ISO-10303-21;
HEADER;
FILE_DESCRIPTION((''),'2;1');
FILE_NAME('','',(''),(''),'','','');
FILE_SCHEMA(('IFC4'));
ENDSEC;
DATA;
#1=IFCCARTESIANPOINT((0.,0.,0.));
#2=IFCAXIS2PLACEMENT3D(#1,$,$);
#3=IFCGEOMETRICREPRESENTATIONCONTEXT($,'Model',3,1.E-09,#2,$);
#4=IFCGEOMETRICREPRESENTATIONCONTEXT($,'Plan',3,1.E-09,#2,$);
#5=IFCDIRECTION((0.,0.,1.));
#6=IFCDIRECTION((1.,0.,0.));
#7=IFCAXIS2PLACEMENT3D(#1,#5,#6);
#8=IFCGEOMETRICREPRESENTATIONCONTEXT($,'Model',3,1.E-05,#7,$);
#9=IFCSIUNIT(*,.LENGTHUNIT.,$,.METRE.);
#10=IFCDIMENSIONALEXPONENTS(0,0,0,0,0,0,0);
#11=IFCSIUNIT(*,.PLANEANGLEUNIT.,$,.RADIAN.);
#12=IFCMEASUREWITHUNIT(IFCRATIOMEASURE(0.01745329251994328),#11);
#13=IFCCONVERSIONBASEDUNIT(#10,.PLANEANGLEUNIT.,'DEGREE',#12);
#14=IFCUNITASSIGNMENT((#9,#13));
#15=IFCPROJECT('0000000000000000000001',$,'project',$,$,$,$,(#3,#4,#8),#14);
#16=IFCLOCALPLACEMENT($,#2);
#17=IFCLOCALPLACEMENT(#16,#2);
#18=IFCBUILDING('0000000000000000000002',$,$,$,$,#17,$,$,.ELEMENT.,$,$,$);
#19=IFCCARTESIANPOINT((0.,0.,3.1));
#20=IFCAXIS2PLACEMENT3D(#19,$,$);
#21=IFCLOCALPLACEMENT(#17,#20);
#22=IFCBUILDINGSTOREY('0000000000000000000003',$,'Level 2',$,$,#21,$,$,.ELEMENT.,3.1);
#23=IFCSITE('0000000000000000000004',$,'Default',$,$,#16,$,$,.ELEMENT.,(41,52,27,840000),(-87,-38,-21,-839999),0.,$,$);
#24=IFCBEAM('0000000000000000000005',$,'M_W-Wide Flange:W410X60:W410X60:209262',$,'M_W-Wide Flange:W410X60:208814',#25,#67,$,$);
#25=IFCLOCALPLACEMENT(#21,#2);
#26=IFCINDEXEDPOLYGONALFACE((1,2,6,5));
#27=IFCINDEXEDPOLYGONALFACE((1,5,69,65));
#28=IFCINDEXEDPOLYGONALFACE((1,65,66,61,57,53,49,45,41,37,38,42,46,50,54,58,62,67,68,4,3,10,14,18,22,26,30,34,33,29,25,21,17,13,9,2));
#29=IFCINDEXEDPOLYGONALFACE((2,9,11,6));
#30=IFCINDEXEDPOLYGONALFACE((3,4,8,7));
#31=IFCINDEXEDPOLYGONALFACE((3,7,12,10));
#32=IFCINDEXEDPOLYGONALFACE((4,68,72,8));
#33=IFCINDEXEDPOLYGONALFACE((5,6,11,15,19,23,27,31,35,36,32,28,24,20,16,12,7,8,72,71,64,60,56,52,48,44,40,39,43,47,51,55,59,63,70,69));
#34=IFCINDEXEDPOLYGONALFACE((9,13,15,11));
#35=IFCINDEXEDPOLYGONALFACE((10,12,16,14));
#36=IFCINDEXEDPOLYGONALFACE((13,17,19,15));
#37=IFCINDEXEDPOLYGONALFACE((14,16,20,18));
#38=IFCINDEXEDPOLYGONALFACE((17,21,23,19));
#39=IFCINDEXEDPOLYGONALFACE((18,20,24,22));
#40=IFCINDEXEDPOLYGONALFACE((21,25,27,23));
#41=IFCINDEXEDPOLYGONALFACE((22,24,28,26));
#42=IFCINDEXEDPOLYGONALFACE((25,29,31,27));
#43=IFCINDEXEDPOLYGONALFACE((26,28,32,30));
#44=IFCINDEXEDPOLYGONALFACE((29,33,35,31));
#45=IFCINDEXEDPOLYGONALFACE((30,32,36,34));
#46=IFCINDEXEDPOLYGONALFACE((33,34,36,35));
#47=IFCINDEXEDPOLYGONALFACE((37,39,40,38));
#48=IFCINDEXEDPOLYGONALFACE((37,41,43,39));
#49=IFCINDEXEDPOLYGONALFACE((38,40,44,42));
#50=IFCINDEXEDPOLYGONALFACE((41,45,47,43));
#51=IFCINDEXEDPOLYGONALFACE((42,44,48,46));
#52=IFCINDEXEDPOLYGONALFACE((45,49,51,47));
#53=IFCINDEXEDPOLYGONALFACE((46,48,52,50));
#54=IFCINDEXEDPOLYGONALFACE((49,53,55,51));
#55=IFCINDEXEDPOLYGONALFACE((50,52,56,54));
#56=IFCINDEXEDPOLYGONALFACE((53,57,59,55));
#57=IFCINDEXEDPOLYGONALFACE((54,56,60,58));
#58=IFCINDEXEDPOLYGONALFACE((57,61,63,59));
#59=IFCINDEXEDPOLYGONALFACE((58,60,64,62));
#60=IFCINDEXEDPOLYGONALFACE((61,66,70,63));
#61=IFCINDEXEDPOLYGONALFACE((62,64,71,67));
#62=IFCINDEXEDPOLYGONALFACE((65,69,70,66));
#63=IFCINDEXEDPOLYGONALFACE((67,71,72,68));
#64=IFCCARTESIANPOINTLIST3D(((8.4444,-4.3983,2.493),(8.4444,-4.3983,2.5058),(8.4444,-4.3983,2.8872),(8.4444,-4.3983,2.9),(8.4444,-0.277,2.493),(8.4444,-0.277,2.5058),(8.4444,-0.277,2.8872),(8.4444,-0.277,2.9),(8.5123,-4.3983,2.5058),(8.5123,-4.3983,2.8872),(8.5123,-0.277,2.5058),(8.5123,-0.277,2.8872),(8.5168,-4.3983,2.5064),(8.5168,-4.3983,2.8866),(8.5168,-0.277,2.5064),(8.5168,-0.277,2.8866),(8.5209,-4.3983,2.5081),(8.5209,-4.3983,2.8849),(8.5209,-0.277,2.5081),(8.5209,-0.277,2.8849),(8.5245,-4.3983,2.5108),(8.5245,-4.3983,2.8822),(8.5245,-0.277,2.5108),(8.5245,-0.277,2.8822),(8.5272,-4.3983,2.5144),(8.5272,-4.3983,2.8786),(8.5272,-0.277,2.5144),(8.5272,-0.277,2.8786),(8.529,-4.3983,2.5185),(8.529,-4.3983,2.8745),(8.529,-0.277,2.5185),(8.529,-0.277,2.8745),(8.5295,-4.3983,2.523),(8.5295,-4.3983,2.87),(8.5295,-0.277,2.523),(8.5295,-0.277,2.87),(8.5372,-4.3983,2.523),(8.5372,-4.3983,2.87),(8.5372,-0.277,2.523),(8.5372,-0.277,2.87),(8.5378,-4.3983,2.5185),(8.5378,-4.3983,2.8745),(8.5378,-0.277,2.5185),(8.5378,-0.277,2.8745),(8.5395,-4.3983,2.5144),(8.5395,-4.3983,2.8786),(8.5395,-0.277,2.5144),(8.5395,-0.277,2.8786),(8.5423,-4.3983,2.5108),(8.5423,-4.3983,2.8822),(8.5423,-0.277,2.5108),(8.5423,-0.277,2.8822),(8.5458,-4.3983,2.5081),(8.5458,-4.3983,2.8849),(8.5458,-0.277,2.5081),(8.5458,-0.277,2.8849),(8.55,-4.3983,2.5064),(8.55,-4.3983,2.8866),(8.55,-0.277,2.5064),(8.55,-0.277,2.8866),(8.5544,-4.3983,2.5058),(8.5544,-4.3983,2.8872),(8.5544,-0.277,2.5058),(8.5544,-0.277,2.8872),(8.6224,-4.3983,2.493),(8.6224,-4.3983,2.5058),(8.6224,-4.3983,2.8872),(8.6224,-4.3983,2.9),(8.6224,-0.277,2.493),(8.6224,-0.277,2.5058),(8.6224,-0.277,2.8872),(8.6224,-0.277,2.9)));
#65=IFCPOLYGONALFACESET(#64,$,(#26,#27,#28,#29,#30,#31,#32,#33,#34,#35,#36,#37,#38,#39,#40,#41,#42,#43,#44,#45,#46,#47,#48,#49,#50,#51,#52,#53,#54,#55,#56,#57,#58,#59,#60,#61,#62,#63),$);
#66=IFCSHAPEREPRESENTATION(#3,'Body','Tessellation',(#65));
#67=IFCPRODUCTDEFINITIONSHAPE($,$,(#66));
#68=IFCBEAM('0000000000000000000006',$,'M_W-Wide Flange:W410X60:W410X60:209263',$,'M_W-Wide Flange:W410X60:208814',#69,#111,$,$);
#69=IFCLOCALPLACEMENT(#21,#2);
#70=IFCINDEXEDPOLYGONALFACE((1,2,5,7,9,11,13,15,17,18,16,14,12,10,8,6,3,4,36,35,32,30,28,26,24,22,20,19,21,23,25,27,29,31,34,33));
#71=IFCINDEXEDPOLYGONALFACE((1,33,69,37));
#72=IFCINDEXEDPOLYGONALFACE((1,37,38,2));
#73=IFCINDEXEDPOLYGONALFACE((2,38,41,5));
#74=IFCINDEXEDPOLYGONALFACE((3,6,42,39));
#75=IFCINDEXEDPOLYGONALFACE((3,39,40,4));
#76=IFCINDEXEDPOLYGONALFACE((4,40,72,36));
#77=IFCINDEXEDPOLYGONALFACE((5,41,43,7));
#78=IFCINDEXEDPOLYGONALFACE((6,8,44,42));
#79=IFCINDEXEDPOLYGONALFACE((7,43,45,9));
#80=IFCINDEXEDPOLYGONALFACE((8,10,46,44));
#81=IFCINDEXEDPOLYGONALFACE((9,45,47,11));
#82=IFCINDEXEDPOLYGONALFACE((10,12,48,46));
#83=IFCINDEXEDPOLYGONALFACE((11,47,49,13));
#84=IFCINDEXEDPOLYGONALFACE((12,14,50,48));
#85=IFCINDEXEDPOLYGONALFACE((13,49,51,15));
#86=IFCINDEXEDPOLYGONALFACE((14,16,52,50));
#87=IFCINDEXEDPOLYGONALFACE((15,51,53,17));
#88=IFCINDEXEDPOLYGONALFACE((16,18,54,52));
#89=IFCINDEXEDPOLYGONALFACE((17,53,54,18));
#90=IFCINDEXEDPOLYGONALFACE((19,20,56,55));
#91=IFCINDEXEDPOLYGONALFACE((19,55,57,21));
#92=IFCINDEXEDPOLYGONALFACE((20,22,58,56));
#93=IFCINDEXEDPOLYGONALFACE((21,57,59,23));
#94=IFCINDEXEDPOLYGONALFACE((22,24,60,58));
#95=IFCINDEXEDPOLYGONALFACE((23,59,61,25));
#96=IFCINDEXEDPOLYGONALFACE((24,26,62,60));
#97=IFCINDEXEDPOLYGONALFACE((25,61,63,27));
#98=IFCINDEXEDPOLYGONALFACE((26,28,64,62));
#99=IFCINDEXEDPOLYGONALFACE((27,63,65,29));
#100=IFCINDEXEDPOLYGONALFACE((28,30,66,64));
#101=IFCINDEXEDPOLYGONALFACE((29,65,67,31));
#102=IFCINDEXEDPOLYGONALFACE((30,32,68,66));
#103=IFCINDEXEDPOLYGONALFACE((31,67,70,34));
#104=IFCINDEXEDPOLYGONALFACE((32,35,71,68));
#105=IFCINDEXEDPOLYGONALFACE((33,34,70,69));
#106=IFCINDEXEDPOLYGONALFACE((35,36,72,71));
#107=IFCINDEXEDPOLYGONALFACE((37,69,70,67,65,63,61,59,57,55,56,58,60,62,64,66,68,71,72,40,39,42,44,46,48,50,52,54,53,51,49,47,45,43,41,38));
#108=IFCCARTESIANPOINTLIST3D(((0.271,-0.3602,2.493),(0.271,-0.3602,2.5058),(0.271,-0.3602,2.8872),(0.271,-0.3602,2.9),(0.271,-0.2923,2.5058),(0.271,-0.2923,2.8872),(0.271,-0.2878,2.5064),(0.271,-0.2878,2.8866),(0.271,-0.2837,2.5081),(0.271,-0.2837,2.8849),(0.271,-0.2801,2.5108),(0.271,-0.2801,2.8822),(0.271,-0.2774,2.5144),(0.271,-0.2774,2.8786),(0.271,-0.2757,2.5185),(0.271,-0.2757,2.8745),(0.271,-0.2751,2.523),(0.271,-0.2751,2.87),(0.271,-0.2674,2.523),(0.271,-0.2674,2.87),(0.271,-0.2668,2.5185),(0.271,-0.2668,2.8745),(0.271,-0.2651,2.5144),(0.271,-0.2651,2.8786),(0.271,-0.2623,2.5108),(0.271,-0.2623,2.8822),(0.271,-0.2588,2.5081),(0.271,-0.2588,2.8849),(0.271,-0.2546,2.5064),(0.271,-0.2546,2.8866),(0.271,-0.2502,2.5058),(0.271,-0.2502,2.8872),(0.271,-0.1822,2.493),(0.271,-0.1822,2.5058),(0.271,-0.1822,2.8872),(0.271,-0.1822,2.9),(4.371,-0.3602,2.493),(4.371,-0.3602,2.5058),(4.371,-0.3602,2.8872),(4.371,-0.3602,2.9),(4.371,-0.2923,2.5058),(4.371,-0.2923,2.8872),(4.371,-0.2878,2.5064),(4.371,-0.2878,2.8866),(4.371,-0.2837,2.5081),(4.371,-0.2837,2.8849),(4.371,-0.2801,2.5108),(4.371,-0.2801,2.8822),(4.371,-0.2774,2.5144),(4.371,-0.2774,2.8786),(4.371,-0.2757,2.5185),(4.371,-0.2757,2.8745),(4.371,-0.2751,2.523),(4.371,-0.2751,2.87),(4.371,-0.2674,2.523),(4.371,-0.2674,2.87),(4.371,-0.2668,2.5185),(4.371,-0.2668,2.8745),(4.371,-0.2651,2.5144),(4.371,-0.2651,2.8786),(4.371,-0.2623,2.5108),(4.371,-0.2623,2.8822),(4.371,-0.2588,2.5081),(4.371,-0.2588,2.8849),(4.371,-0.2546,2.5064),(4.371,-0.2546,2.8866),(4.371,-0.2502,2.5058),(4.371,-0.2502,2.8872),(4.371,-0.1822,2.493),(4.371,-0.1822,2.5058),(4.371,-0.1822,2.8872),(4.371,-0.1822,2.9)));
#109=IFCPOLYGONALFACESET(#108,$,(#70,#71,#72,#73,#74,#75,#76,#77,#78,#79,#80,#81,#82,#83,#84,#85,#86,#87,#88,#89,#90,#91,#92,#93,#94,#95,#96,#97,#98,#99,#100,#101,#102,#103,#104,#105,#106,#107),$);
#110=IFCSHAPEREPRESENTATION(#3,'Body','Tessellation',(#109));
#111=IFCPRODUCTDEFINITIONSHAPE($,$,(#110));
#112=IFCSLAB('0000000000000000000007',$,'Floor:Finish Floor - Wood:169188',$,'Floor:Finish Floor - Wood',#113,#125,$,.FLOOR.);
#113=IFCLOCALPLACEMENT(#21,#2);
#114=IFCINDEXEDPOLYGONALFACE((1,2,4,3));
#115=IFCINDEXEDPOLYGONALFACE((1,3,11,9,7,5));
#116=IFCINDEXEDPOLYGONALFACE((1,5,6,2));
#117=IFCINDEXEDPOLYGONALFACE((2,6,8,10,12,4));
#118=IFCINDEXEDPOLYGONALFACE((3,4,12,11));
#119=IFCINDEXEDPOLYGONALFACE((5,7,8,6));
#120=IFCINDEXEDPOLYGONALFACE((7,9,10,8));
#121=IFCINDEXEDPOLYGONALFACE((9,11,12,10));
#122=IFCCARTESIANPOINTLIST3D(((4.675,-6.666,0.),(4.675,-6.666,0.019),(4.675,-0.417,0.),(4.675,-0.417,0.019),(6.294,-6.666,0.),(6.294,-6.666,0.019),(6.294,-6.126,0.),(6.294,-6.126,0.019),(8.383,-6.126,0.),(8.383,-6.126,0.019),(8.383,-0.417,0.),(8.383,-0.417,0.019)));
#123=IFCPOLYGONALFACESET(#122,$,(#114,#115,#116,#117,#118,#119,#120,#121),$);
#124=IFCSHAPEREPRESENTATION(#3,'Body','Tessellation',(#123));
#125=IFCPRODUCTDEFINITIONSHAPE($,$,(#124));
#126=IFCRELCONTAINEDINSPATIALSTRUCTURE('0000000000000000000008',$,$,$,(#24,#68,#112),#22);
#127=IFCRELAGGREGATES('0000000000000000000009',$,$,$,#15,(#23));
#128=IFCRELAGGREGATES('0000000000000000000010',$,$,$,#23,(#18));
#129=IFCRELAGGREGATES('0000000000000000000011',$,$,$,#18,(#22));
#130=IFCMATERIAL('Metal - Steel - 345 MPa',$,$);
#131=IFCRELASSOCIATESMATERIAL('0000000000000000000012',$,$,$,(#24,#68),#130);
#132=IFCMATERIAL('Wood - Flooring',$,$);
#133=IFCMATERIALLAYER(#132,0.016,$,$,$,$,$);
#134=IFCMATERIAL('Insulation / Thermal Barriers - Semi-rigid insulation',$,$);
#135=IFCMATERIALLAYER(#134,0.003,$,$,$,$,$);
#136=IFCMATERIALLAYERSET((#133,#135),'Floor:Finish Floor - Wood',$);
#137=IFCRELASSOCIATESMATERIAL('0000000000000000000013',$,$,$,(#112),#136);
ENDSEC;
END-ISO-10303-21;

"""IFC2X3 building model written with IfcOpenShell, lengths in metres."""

from ifc_helpers import new_model, entity, si_unit, converted_unit, frame, frame_2d, origin, origin_with_axes, place, context, project, spatial, polyline, circle_curve, parameter, trimmed, segment, composite_curve, outline, extrude, material, layer, layer_set, layer_usage, element, save


model = new_model("IFC2X3")

# Units and contexts
model_context_1 = context("Model", 3, precision=1e-09, world=origin())
plan_context = context("Plan", 3, precision=1e-09, world=origin())
model_context_2 = context("Model", 3, precision=1e-05, world=origin_with_axes())
ifc_project = project(units=[si_unit("LENGTHUNIT", "METRE"), converted_unit("PLANEANGLEUNIT", "DEGREE", entity("IfcRatioMeasure", 0.01745329251994328), si_unit("PLANEANGLEUNIT", "RADIAN"), dimensions=[0, 0, 0, 0, 0, 0, 0])], contexts=[model_context_1, plan_context, model_context_2])

# Site, building, storey
site_placement = place(None, origin())
site = spatial("IfcSite", under=ifc_project, at=site_placement, Name="Default", CompositionType="ELEMENT", RefLatitude=(41, 52, 27, 840000), RefLongitude=(-87, -38, -21, -839999), RefElevation=0.0)
building_placement = place(site_placement, origin())
building = spatial("IfcBuilding", under=site, at=building_placement, CompositionType="ELEMENT")
storey_placement = place(building_placement, frame((0.0, 0.0, 3.1)))
storey = spatial("IfcBuildingStorey", under=building, at=storey_placement, Name="Level 2", CompositionType="ELEMENT", Elevation=3.1)

# Beams
ifc_material_1 = material(Name="Metal - Steel - 345 MPa")
beam_1_placement = place(storey_placement, frame((8.5334, -4.3983, 2.9)))
element("IfcBeam", 1, at=beam_1_placement, inside=storey, material=ifc_material_1, Name="M_W-Wide Flange:W410X60:W410X60:209262", ObjectType="M_W-Wide Flange:W410X60:208814", context=model_context_1, shape_type="SweptSolid", body=[
    extrude(outline(composite_curve([segment(polyline([(-0.089, -0.1907), (-0.089, -0.2035)]), True, "CONTINUOUS"), segment(polyline([(-0.089, -0.2035), (0.089, -0.2035)]), True, "CONTINUOUS"), segment(polyline([(0.089, -0.2035), (0.089, -0.1907)]), True, "CONTINUOUS"), segment(polyline([(0.089, -0.1907), (0.021, -0.1907)]), True, "CONTINUOUS"), segment(trimmed(circle_curve(frame_2d((0.021, -0.1735), x_axis=(0.0, -1.0)), 0.0172), [parameter(270.0)], [parameter(360.0)], True, "PARAMETER"), False, "CONTINUOUS"), segment(polyline([(0.0038, -0.1735), (0.0038, 0.1735)]), True, "CONTINUOUS"), segment(trimmed(circle_curve(frame_2d((0.021, 0.1735), x_axis=(-1.0, 0.0)), 0.0172), [parameter(270.0)], [parameter(360.0)], True, "PARAMETER"), False, "CONTINUOUS"), segment(polyline([(0.021, 0.1907), (0.089, 0.1907)]), True, "CONTINUOUS"), segment(polyline([(0.089, 0.1907), (0.089, 0.2035)]), True, "CONTINUOUS"), segment(polyline([(0.089, 0.2035), (-0.089, 0.2035)]), True, "CONTINUOUS"), segment(polyline([(-0.089, 0.2035), (-0.089, 0.1907)]), True, "CONTINUOUS"), segment(polyline([(-0.089, 0.1907), (-0.0211, 0.1907)]), True, "CONTINUOUS"), segment(trimmed(circle_curve(frame_2d((-0.0211, 0.1735), x_axis=(0.0, 1.0)), 0.0172), [parameter(270.0)], [parameter(0.0)], True, "PARAMETER"), False, "CONTINUOUS"), segment(polyline([(-0.0039, 0.1735), (-0.0039, -0.1735)]), True, "CONTINUOUS"), segment(trimmed(circle_curve(frame_2d((-0.0211, -0.1735), x_axis=(1.0, 0.0)), 0.0172), [parameter(270.0)], [parameter(0.0)], True, "PARAMETER"), False, "CONTINUOUS"), segment(polyline([(-0.0211, -0.1907), (-0.089, -0.1907)]), True, "CONTINUOUS")], self_intersect=False)), frame((0.0, 0.0, -0.2035), z_axis=(0.0, -1.0, 0.0), x_axis=(1.0, 0.0, 0.0)), (0.0, 0.0, -1.0), 4.1213),
])
beam_2_placement = place(storey_placement, frame((4.371, -0.2712, 2.9), z_axis=(0.0, 0.0, 1.0), x_axis=(0.0, 1.0, 0.0)))
element("IfcBeam", 2, at=beam_2_placement, inside=storey, material=ifc_material_1, Name="M_W-Wide Flange:W410X60:W410X60:209263", ObjectType="M_W-Wide Flange:W410X60:208814", context=model_context_1, shape_type="SweptSolid", body=[
    extrude(outline(composite_curve([segment(polyline([(0.1907, -0.089), (0.2035, -0.089)]), True, "CONTINUOUS"), segment(polyline([(0.2035, -0.089), (0.2035, 0.089)]), True, "CONTINUOUS"), segment(polyline([(0.2035, 0.089), (0.1907, 0.089)]), True, "CONTINUOUS"), segment(polyline([(0.1907, 0.089), (0.1907, 0.0211)]), True, "CONTINUOUS"), segment(trimmed(circle_curve(frame_2d((0.1735, 0.0211), x_axis=(1.0, 0.0)), 0.0172), [parameter(270.0)], [parameter(360.0)], True, "PARAMETER"), False, "CONTINUOUS"), segment(polyline([(0.1735, 0.0039), (-0.1735, 0.0039)]), True, "CONTINUOUS"), segment(trimmed(circle_curve(frame_2d((-0.1735, 0.0211), x_axis=(0.0, -1.0)), 0.0172), [parameter(270.0)], [parameter(360.0)], True, "PARAMETER"), False, "CONTINUOUS"), segment(polyline([(-0.1907, 0.0211), (-0.1907, 0.089)]), True, "CONTINUOUS"), segment(polyline([(-0.1907, 0.089), (-0.2035, 0.089)]), True, "CONTINUOUS"), segment(polyline([(-0.2035, 0.089), (-0.2035, -0.089)]), True, "CONTINUOUS"), segment(polyline([(-0.2035, -0.089), (-0.1907, -0.089)]), True, "CONTINUOUS"), segment(polyline([(-0.1907, -0.089), (-0.1907, -0.0211)]), True, "CONTINUOUS"), segment(trimmed(circle_curve(frame_2d((-0.1735, -0.0211), x_axis=(-1.0, 0.0)), 0.0172), [parameter(270.0)], [parameter(0.0)], True, "PARAMETER"), False, "CONTINUOUS"), segment(polyline([(-0.1735, -0.0039), (0.1735, -0.0039)]), True, "CONTINUOUS"), segment(trimmed(circle_curve(frame_2d((0.1735, -0.0211), x_axis=(0.0, 1.0)), 0.0172), [parameter(270.0)], [parameter(0.0)], True, "PARAMETER"), False, "CONTINUOUS"), segment(polyline([(0.1907, -0.0211), (0.1907, -0.089)]), True, "CONTINUOUS")], self_intersect=False)), frame((0.0, 4.1, -0.2035), z_axis=(0.0, -1.0, 0.0), x_axis=(0.0, 0.0, -1.0)), (0.0, 0.0, 1.0), 4.1),
])

# Slab
ifc_material_2 = material(Name="Wood - Flooring")
ifc_layer_1 = layer(ifc_material_2, 0.016)
ifc_material_3 = material(Name="Insulation / Thermal Barriers - Semi-rigid insulation")
ifc_layer_2 = layer(ifc_material_3, 0.003)
ifc_layer_set_1 = layer_set([ifc_layer_1, ifc_layer_2], Name="Floor:Finish Floor - Wood")
ifc_layer_usage_1 = layer_usage(ifc_layer_set_1, "AXIS3", "POSITIVE", 0.0)
slab_placement = place(storey_placement, frame((4.675, -6.666, 0.0)))
element("IfcSlab", 3, at=slab_placement, inside=storey, material=ifc_layer_usage_1, Name="Floor:Finish Floor - Wood:169188", ObjectType="Floor:Finish Floor - Wood", PredefinedType="FLOOR", context=model_context_1, shape_type="SweptSolid", body=[
    extrude(outline(polyline([(-1.854, 3.1245), (-1.854, -2.5845), (0.235, -2.5845), (0.235, -3.1245), (1.854, -3.1245), (1.854, 3.1245), (-1.854, 3.1245)])), frame((1.854, 3.1245, 0.019), z_axis=(0.0, 0.0, -1.0), x_axis=(-1.0, 0.0, 0.0)), (0.0, 0.0, 1.0), 0.019),
])

save(model, "model.ifc")
